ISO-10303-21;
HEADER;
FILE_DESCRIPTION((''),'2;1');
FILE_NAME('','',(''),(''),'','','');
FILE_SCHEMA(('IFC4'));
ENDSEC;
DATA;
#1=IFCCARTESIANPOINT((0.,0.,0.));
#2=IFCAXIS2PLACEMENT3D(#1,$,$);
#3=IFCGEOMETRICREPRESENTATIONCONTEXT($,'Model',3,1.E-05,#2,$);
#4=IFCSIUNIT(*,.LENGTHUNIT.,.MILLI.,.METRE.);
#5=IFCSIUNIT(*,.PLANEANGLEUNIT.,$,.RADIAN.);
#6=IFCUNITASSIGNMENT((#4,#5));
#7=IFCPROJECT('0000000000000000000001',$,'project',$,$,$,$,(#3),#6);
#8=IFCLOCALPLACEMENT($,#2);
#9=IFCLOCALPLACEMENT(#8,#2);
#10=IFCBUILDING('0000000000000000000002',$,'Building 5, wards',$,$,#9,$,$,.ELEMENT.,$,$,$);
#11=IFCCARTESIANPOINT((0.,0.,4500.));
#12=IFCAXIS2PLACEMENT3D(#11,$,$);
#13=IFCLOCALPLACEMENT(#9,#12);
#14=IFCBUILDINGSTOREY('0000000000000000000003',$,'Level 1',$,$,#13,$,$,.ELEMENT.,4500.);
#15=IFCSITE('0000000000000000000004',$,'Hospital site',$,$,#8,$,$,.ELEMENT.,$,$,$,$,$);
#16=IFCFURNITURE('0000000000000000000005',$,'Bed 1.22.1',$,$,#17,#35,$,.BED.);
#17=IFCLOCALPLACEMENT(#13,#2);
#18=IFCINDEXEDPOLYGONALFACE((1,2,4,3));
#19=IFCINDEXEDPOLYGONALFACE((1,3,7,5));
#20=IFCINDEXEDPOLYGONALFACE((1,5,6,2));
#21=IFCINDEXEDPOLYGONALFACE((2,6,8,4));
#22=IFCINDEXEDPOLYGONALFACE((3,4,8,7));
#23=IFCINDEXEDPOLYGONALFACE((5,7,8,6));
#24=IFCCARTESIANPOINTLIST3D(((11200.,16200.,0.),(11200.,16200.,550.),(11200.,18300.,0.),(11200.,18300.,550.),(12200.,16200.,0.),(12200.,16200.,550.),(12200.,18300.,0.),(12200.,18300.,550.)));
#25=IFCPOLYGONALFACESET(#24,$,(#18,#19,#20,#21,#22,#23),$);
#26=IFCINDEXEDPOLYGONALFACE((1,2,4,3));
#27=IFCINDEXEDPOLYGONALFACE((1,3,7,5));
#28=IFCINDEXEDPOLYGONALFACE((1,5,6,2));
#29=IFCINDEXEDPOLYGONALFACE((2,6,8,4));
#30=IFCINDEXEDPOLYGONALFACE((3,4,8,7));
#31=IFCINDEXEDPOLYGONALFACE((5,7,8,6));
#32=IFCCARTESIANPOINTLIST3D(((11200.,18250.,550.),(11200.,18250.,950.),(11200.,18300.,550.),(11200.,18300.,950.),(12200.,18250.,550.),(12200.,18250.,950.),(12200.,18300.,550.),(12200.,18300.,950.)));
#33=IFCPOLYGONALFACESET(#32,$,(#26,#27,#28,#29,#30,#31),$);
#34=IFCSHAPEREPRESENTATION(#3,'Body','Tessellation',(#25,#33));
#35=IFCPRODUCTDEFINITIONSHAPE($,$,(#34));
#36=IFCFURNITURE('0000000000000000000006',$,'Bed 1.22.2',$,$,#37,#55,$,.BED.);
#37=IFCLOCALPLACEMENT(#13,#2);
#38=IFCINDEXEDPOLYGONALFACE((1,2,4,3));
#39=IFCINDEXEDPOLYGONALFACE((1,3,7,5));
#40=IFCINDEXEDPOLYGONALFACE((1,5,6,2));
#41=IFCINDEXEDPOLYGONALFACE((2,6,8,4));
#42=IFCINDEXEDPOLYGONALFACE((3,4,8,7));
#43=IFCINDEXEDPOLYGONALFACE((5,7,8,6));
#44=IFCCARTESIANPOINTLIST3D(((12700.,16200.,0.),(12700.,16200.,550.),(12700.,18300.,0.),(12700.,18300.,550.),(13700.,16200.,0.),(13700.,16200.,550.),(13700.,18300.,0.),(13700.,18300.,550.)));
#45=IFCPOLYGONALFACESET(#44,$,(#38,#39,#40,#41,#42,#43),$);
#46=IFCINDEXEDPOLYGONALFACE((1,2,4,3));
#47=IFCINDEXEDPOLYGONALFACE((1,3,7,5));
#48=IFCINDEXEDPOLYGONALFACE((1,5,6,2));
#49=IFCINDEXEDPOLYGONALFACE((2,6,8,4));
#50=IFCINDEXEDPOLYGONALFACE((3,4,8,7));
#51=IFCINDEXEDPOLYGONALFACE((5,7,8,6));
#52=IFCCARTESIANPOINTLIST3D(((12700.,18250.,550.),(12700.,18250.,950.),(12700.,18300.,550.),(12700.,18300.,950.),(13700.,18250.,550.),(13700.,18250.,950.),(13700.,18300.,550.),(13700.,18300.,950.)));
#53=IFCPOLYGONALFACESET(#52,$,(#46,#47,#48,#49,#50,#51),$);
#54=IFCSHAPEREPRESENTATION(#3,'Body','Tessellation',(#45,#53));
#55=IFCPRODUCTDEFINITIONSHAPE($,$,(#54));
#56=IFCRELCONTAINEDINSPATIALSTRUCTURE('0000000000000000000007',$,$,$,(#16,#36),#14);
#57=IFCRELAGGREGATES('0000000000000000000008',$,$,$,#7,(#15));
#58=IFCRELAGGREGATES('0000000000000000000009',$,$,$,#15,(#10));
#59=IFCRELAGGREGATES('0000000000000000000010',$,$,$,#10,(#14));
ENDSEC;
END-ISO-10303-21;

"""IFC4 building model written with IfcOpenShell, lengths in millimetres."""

from ifc_helpers import new_model, si_unit, frame, frame_2d, origin, place, context, project, spatial, rectangle, extrude, element, save


model = new_model("IFC4")

# Units and contexts
model_context = context("Model", 3, precision=1e-05, world=origin())
ifc_project = project(units=[si_unit("LENGTHUNIT", "METRE", prefix="MILLI"), si_unit("PLANEANGLEUNIT", "RADIAN")], contexts=[model_context])

# Site, building, storey
site_placement = place(None, origin())
site = spatial("IfcSite", under=ifc_project, at=site_placement, Name="Hospital site", CompositionType="ELEMENT")
building_placement = place(site_placement, origin())
building = spatial("IfcBuilding", under=site, at=building_placement, Name="Building 5, wards", CompositionType="ELEMENT")
storey_placement = place(building_placement, frame((0.0, 0.0, 4500.0)))
storey = spatial("IfcBuildingStorey", under=building, at=storey_placement, Name="Level 1", CompositionType="ELEMENT", Elevation=4500.0)

# Furniture
for number, where, name in (
    (1, (11200.0, 16200.0, 0.0), "Bed 1.22.1"),
    (2, (12700.0, 16200.0, 0.0), "Bed 1.22.2"),
):
    element("IfcFurniture", number, at=place(storey_placement, frame(where)), inside=storey, Name=name, PredefinedType="BED", context=model_context, shape_type="SweptSolid", body=[
        extrude(rectangle(XDim=1000.0, YDim=2100.0, at=frame_2d((500.0, 1050.0))), origin(), (0.0, 0.0, 1.0), 550.0),
        extrude(rectangle(XDim=1000.0, YDim=50.0, at=frame_2d((500.0, 2075.0))), frame((0.0, 0.0, 550.0)), (0.0, 0.0, 1.0), 400.0),
    ])

save(model, "model.ifc")
